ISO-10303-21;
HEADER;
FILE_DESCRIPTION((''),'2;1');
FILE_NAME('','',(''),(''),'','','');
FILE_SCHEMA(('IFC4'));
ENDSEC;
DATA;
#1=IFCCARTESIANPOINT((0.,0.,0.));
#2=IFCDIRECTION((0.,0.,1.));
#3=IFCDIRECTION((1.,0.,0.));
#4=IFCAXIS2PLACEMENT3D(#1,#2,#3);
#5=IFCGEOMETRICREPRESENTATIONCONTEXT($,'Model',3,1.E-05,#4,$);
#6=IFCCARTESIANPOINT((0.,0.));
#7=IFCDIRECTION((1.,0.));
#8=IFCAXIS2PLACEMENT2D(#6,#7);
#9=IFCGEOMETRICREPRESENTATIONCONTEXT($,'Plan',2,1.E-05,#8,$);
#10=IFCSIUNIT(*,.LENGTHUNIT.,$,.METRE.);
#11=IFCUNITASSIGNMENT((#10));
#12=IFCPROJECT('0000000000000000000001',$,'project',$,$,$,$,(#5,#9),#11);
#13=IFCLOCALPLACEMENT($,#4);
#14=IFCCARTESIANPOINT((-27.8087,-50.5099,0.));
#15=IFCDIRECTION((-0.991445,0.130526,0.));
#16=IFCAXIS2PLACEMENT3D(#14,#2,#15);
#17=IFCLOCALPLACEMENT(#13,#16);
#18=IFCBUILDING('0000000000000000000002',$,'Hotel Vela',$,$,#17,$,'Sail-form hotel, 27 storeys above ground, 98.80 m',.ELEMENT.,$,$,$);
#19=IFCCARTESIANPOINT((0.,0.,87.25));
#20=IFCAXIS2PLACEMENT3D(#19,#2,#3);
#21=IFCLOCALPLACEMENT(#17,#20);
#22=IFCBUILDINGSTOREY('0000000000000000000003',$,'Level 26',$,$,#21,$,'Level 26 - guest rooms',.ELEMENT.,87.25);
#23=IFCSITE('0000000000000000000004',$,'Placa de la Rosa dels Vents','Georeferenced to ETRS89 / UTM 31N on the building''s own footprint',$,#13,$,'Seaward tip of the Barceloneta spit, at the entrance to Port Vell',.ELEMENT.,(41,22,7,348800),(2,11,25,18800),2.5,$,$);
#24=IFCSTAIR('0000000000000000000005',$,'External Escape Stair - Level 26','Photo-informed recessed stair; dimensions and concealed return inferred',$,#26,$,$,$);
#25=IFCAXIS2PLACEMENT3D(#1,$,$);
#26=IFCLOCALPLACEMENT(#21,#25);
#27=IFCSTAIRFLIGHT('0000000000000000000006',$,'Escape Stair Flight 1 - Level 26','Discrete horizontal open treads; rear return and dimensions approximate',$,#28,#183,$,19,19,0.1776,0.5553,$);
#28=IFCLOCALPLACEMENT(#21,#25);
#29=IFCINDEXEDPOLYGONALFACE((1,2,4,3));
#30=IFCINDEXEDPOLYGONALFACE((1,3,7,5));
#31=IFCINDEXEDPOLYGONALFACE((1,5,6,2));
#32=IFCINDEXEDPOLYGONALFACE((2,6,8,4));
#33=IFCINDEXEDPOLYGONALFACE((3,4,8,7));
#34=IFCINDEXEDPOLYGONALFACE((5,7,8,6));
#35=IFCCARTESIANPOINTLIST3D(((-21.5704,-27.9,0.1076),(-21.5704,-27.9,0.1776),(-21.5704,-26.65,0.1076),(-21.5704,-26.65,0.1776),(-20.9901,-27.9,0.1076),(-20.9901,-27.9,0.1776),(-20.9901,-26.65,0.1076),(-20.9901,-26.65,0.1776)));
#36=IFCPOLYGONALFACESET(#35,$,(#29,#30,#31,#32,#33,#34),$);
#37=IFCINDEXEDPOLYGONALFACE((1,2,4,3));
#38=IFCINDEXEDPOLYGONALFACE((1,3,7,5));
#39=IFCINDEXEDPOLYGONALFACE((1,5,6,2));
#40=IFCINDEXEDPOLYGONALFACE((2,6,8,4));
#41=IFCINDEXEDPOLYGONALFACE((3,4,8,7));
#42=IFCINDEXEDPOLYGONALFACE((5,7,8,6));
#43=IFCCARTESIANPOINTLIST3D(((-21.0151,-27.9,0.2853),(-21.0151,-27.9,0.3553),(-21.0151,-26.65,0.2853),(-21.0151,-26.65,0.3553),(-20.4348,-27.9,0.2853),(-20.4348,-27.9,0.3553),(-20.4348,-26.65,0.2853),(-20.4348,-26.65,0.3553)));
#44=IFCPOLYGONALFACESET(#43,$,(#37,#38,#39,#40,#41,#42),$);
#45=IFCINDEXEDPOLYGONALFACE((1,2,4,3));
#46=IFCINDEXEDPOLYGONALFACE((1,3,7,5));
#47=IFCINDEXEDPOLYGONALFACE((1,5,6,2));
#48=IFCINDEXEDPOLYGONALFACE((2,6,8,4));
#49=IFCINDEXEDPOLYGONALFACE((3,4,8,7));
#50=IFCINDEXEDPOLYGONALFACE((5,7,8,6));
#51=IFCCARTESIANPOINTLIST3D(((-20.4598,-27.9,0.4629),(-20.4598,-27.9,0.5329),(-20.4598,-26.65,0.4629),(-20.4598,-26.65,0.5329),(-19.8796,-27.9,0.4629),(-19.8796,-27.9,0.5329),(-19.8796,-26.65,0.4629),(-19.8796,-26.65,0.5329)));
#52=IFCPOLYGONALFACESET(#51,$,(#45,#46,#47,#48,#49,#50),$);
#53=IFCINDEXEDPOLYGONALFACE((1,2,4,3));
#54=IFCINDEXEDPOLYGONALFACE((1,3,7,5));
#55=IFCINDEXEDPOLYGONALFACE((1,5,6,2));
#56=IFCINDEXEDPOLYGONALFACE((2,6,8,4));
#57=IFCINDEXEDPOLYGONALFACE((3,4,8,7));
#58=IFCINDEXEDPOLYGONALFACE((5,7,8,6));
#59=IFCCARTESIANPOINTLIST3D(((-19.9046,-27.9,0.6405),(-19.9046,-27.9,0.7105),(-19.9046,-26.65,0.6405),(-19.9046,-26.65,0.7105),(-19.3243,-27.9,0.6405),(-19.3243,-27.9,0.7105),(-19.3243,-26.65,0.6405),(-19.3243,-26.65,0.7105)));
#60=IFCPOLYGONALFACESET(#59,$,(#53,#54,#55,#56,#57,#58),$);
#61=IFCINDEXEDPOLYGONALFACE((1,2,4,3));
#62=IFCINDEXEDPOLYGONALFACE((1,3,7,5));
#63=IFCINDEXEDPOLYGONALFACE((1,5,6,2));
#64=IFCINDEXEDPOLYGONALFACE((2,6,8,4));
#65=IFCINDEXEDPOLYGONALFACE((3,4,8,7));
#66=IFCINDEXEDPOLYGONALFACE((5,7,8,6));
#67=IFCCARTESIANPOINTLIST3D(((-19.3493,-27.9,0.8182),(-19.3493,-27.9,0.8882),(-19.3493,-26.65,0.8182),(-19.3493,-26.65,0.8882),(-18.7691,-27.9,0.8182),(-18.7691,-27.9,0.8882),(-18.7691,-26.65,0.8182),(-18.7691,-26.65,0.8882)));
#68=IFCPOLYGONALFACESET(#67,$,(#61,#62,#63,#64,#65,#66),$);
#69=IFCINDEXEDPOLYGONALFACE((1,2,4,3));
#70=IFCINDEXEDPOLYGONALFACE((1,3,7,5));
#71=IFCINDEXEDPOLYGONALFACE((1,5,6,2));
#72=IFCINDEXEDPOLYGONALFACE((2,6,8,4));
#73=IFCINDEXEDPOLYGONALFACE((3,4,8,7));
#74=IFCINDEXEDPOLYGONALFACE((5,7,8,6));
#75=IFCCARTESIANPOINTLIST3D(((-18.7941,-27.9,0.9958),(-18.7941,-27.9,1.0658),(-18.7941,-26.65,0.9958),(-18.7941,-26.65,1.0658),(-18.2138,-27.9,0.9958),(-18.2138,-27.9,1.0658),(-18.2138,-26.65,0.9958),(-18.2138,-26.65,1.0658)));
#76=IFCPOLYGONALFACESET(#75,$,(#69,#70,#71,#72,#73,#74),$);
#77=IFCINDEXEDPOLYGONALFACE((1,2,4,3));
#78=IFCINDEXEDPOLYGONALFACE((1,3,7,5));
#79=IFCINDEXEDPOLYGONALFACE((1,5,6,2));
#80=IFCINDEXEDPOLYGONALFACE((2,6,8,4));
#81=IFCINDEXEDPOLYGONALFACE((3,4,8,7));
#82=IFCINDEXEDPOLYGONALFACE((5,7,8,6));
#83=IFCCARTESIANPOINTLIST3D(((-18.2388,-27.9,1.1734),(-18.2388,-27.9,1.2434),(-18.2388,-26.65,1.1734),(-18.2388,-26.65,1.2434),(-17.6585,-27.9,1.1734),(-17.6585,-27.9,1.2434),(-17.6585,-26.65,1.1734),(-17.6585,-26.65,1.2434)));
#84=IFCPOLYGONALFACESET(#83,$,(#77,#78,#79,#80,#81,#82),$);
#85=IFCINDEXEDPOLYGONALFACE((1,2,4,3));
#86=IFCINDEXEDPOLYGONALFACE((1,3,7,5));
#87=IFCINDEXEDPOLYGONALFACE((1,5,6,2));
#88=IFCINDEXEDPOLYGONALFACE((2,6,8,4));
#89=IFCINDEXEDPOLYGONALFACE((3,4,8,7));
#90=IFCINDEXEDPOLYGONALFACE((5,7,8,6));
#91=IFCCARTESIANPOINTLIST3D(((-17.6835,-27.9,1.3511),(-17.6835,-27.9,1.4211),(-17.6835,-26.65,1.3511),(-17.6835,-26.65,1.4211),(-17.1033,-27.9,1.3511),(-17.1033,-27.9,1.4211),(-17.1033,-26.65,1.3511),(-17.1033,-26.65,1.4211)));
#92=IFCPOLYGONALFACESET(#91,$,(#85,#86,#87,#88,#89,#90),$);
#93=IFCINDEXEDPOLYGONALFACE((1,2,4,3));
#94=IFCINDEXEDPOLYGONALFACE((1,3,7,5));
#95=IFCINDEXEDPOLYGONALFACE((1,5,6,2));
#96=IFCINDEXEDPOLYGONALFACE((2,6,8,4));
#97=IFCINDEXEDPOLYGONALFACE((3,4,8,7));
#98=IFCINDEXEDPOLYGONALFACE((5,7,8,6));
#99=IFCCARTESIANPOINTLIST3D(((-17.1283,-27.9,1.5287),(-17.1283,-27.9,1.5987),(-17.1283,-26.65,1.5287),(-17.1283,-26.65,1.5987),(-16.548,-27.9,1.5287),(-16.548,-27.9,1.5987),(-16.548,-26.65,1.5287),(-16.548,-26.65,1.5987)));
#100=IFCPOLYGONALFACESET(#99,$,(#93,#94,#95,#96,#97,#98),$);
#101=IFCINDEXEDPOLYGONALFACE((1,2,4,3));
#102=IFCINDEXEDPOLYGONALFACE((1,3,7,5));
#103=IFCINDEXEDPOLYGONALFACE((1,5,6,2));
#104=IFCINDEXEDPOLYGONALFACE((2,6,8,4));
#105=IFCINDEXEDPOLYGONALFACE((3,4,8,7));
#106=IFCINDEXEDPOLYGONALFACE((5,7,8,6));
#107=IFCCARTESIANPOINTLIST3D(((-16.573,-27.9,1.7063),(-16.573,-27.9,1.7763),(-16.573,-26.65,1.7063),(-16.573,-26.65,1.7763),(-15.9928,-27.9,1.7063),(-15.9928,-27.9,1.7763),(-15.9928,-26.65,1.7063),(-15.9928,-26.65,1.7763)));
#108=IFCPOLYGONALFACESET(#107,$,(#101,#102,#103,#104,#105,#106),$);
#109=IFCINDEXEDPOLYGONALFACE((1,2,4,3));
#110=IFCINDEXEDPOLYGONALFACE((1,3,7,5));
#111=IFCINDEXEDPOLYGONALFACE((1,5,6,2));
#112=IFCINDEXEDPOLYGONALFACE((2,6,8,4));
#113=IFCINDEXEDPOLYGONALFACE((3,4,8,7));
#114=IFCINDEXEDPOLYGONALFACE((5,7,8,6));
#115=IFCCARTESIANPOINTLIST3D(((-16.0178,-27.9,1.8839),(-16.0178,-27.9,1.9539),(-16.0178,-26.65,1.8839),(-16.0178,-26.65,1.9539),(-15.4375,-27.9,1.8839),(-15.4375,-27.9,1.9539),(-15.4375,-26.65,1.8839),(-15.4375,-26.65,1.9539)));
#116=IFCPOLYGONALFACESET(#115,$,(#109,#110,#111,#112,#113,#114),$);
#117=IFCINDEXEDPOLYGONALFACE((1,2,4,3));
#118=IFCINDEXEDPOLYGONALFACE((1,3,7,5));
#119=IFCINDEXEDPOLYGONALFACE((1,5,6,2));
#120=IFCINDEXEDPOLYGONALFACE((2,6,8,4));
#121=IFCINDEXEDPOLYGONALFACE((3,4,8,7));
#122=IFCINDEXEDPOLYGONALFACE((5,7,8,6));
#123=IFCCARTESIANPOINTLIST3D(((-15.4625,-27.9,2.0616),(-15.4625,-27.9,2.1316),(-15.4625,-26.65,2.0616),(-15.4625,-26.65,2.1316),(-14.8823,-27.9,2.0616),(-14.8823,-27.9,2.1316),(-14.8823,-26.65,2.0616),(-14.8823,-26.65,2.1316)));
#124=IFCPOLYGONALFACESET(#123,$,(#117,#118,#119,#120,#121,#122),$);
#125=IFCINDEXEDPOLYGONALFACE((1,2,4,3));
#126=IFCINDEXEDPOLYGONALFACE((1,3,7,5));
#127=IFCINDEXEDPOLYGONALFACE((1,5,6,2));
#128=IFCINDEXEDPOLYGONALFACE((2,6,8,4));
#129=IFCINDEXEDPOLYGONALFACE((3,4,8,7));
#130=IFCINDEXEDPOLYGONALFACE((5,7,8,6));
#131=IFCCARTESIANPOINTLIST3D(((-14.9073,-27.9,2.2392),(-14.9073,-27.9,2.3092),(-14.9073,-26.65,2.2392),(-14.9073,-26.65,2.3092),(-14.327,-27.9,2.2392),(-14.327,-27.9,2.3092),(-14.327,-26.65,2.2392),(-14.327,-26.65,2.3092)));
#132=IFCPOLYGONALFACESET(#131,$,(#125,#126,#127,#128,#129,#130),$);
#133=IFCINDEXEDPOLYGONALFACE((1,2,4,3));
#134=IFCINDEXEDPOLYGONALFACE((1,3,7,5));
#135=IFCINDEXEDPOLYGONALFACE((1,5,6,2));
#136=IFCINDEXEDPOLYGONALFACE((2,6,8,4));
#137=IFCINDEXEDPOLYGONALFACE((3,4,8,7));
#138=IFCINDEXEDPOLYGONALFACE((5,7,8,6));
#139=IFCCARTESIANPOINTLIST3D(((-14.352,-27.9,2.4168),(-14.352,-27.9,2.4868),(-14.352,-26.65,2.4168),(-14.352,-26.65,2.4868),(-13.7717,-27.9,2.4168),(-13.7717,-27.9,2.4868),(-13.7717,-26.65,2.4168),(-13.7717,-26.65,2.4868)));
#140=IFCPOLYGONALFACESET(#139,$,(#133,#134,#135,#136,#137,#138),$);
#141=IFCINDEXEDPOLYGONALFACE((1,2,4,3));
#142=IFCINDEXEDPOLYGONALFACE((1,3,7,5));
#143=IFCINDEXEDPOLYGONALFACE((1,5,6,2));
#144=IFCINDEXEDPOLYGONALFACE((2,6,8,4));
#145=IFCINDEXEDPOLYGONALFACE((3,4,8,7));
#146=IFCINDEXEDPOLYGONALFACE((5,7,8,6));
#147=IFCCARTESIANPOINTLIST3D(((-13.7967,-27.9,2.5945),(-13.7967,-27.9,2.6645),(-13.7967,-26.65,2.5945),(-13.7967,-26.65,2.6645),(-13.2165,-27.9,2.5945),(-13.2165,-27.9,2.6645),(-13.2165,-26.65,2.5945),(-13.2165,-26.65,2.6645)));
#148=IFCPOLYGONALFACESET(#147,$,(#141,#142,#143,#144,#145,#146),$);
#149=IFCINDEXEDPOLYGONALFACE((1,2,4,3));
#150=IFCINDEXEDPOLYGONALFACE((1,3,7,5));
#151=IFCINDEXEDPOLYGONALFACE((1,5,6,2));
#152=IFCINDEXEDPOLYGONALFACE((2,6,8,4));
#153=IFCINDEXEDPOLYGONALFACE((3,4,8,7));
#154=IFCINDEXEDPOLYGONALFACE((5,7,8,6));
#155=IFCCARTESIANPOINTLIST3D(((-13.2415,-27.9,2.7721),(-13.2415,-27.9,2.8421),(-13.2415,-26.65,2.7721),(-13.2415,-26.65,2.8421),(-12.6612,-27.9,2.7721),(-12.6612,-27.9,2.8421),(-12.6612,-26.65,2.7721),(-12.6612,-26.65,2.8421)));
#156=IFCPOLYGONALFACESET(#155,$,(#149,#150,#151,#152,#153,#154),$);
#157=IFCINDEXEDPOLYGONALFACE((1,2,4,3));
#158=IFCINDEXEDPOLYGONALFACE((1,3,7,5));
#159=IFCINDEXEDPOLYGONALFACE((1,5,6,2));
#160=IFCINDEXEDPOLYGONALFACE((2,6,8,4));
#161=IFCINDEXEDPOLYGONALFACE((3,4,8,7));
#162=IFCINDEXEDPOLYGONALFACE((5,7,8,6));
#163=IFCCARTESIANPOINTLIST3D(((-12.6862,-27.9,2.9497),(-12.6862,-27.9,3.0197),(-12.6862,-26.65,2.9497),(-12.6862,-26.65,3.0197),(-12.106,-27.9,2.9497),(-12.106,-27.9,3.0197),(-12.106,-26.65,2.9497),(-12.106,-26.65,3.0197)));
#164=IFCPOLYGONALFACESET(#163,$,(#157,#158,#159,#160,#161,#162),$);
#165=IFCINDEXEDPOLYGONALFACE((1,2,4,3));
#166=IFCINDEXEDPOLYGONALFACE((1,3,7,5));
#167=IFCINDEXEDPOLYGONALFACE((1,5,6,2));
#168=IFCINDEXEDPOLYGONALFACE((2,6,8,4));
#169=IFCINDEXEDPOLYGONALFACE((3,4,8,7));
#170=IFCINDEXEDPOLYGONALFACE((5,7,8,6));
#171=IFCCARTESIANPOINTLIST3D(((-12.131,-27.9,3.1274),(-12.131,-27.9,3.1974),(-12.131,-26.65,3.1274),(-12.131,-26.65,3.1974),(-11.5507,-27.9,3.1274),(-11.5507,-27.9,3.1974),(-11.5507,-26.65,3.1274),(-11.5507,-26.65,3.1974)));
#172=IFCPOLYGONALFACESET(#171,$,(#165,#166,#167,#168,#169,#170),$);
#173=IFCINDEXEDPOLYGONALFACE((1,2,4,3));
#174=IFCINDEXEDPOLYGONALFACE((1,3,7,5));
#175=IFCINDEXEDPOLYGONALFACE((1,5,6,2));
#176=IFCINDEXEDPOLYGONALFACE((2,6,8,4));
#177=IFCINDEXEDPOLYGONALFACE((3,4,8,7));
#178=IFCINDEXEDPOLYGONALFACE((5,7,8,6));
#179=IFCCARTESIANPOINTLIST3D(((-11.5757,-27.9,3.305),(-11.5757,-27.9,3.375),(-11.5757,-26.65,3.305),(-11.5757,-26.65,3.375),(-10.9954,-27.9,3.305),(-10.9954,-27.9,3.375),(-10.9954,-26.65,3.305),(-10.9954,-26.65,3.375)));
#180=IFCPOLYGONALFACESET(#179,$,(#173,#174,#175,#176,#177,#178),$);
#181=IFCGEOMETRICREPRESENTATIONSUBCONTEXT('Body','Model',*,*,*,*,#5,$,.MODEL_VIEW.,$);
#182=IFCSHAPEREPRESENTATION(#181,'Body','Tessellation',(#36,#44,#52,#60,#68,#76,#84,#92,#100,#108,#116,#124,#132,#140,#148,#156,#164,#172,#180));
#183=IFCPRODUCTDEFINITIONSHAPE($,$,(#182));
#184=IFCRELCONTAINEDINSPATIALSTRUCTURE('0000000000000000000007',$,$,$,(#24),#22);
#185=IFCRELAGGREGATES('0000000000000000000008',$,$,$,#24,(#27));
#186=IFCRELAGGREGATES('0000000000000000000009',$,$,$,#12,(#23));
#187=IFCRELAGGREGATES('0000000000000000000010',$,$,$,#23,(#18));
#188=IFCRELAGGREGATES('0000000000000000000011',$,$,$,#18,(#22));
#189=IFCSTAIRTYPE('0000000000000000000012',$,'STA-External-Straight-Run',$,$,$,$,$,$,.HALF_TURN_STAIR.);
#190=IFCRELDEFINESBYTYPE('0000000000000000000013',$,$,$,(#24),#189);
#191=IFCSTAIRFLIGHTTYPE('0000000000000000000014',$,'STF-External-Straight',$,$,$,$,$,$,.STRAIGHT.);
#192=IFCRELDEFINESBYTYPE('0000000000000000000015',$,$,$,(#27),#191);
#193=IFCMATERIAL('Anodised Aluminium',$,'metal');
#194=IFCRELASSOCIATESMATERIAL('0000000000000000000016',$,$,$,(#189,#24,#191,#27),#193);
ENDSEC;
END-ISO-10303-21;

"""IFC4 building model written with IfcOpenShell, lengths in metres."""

from ifc_helpers import new_model, si_unit, frame, origin_with_axes, origin_2d_with_axis, place, context, subcontext, project, spatial, line, indexed_curve, outline, extrude, material, type_object, element, aggregate, save


model = new_model("IFC4")

# Units and contexts
model_context = context("Model", 3, precision=1e-05, world=origin_with_axes())
plan_context = context("Plan", 2, precision=1e-05, world=origin_2d_with_axis())
body_context = subcontext(model_context, "Body", "Model", "MODEL_VIEW")
ifc_project = project(units=[si_unit("LENGTHUNIT", "METRE")], contexts=[model_context, plan_context])

# Site, building, storey
site_placement = place(None, origin_with_axes())
site = spatial("IfcSite", under=ifc_project, at=site_placement, Name="Placa de la Rosa dels Vents", Description="Georeferenced to ETRS89 / UTM 31N on the building's own footprint", LongName="Seaward tip of the Barceloneta spit, at the entrance to Port Vell", CompositionType="ELEMENT", RefLatitude=(41, 22, 7, 348800), RefLongitude=(2, 11, 25, 18800), RefElevation=2.5)
building_placement = place(site_placement, frame((-27.8087, -50.5099, 0.0), z_axis=(0.0, 0.0, 1.0), x_axis=(-0.991445, 0.130526, 0.0)))
building = spatial("IfcBuilding", under=site, at=building_placement, Name="Hotel Vela", LongName="Sail-form hotel, 27 storeys above ground, 98.80 m", CompositionType="ELEMENT")
storey_placement = place(building_placement, frame((0.0, 0.0, 87.25), z_axis=(0.0, 0.0, 1.0), x_axis=(1.0, 0.0, 0.0)))
storey = spatial("IfcBuildingStorey", under=building, at=storey_placement, Name="Level 26", LongName="Level 26 - guest rooms", CompositionType="ELEMENT", Elevation=87.25)

# Stair
ifc_material_1 = material(Name="Anodised Aluminium", Category="metal")
stair_type = type_object("IfcStairType", Name="STA-External-Straight-Run", PredefinedType="HALF_TURN_STAIR", material=ifc_material_1)
stair_placement = place(storey_placement, frame((0.0, 0.0, -87.25), z_axis=(0.0, 0.0, 1.0), x_axis=(1.0, 0.0, 0.0)))
stair = element("IfcStair", 1, at=stair_placement, inside=storey, type_object=stair_type, material=ifc_material_1, Name="External Escape Stair - Level 26", Description="Photo-informed recessed stair; dimensions and concealed return inferred")

# Stair flight
stair_flight_type = type_object("IfcStairFlightType", Name="STF-External-Straight", PredefinedType="STRAIGHT", material=ifc_material_1)
stair_flight_1_placement = place(stair_placement, origin_with_axes())
stair_flight_1 = element("IfcStairFlight", 2, at=stair_flight_1_placement, type_object=stair_flight_type, material=ifc_material_1, Name="Escape Stair Flight 1 - Level 26", Description="Discrete horizontal open treads; rear return and dimensions approximate", NumberOfRisers=19, NumberOfTreads=19, RiserHeight=0.1776, TreadLength=0.5553, context=body_context, shape_type="SweptSolid", body=[
    extrude(outline(indexed_curve([(0.0, 0.0), (0.5803, 0.0), (0.5803, 1.25), (0.0, 1.25)], segments=[line(1, 2, 3, 4, 1)])), frame((-21.5704, -27.9, 87.3576), z_axis=(0.0, 0.0, 1.0), x_axis=(1.0, 0.0, 0.0)), (0.0, 0.0, 1.0), 0.07),
    extrude(outline(indexed_curve([(0.0, 0.0), (0.5803, 0.0), (0.5803, 1.25), (0.0, 1.25)], segments=[line(1, 2, 3, 4, 1)])), frame((-21.0151, -27.9, 87.5353), z_axis=(0.0, 0.0, 1.0), x_axis=(1.0, 0.0, 0.0)), (0.0, 0.0, 1.0), 0.07),
    extrude(outline(indexed_curve([(0.0, 0.0), (0.5803, 0.0), (0.5803, 1.25), (0.0, 1.25)], segments=[line(1, 2, 3, 4, 1)])), frame((-20.4598, -27.9, 87.7129), z_axis=(0.0, 0.0, 1.0), x_axis=(1.0, 0.0, 0.0)), (0.0, 0.0, 1.0), 0.07),
    extrude(outline(indexed_curve([(0.0, 0.0), (0.5803, 0.0), (0.5803, 1.25), (0.0, 1.25)], segments=[line(1, 2, 3, 4, 1)])), frame((-19.9046, -27.9, 87.8905), z_axis=(0.0, 0.0, 1.0), x_axis=(1.0, 0.0, 0.0)), (0.0, 0.0, 1.0), 0.07),
    extrude(outline(indexed_curve([(0.0, 0.0), (0.5803, 0.0), (0.5803, 1.25), (0.0, 1.25)], segments=[line(1, 2, 3, 4, 1)])), frame((-19.3493, -27.9, 88.0682), z_axis=(0.0, 0.0, 1.0), x_axis=(1.0, 0.0, 0.0)), (0.0, 0.0, 1.0), 0.07),
    extrude(outline(indexed_curve([(0.0, 0.0), (0.5803, 0.0), (0.5803, 1.25), (0.0, 1.25)], segments=[line(1, 2, 3, 4, 1)])), frame((-18.7941, -27.9, 88.2458), z_axis=(0.0, 0.0, 1.0), x_axis=(1.0, 0.0, 0.0)), (0.0, 0.0, 1.0), 0.07),
    extrude(outline(indexed_curve([(0.0, 0.0), (0.5803, 0.0), (0.5803, 1.25), (0.0, 1.25)], segments=[line(1, 2, 3, 4, 1)])), frame((-18.2388, -27.9, 88.4234), z_axis=(0.0, 0.0, 1.0), x_axis=(1.0, 0.0, 0.0)), (0.0, 0.0, 1.0), 0.07),
    extrude(outline(indexed_curve([(0.0, 0.0), (0.5803, 0.0), (0.5803, 1.25), (0.0, 1.25)], segments=[line(1, 2, 3, 4, 1)])), frame((-17.6835, -27.9, 88.6011), z_axis=(0.0, 0.0, 1.0), x_axis=(1.0, 0.0, 0.0)), (0.0, 0.0, 1.0), 0.07),
    extrude(outline(indexed_curve([(0.0, 0.0), (0.5803, 0.0), (0.5803, 1.25), (0.0, 1.25)], segments=[line(1, 2, 3, 4, 1)])), frame((-17.1283, -27.9, 88.7787), z_axis=(0.0, 0.0, 1.0), x_axis=(1.0, 0.0, 0.0)), (0.0, 0.0, 1.0), 0.07),
    extrude(outline(indexed_curve([(0.0, 0.0), (0.5803, 0.0), (0.5803, 1.25), (0.0, 1.25)], segments=[line(1, 2, 3, 4, 1)])), frame((-16.573, -27.9, 88.9563), z_axis=(0.0, 0.0, 1.0), x_axis=(1.0, 0.0, 0.0)), (0.0, 0.0, 1.0), 0.07),
    extrude(outline(indexed_curve([(0.0, 0.0), (0.5803, 0.0), (0.5803, 1.25), (0.0, 1.25)], segments=[line(1, 2, 3, 4, 1)])), frame((-16.0178, -27.9, 89.1339), z_axis=(0.0, 0.0, 1.0), x_axis=(1.0, 0.0, 0.0)), (0.0, 0.0, 1.0), 0.07),
    extrude(outline(indexed_curve([(0.0, 0.0), (0.5803, 0.0), (0.5803, 1.25), (0.0, 1.25)], segments=[line(1, 2, 3, 4, 1)])), frame((-15.4625, -27.9, 89.3116), z_axis=(0.0, 0.0, 1.0), x_axis=(1.0, 0.0, 0.0)), (0.0, 0.0, 1.0), 0.07),
    extrude(outline(indexed_curve([(0.0, 0.0), (0.5803, 0.0), (0.5803, 1.25), (0.0, 1.25)], segments=[line(1, 2, 3, 4, 1)])), frame((-14.9073, -27.9, 89.4892), z_axis=(0.0, 0.0, 1.0), x_axis=(1.0, 0.0, 0.0)), (0.0, 0.0, 1.0), 0.07),
    extrude(outline(indexed_curve([(0.0, 0.0), (0.5803, 0.0), (0.5803, 1.25), (0.0, 1.25)], segments=[line(1, 2, 3, 4, 1)])), frame((-14.352, -27.9, 89.6668), z_axis=(0.0, 0.0, 1.0), x_axis=(1.0, 0.0, 0.0)), (0.0, 0.0, 1.0), 0.07),
    extrude(outline(indexed_curve([(0.0, 0.0), (0.5803, 0.0), (0.5803, 1.25), (0.0, 1.25)], segments=[line(1, 2, 3, 4, 1)])), frame((-13.7967, -27.9, 89.8445), z_axis=(0.0, 0.0, 1.0), x_axis=(1.0, 0.0, 0.0)), (0.0, 0.0, 1.0), 0.07),
    extrude(outline(indexed_curve([(0.0, 0.0), (0.5803, 0.0), (0.5803, 1.25), (0.0, 1.25)], segments=[line(1, 2, 3, 4, 1)])), frame((-13.2415, -27.9, 90.0221), z_axis=(0.0, 0.0, 1.0), x_axis=(1.0, 0.0, 0.0)), (0.0, 0.0, 1.0), 0.07),
    extrude(outline(indexed_curve([(0.0, 0.0), (0.5803, 0.0), (0.5803, 1.25), (0.0, 1.25)], segments=[line(1, 2, 3, 4, 1)])), frame((-12.6862, -27.9, 90.1997), z_axis=(0.0, 0.0, 1.0), x_axis=(1.0, 0.0, 0.0)), (0.0, 0.0, 1.0), 0.07),
    extrude(outline(indexed_curve([(0.0, 0.0), (0.5803, 0.0), (0.5803, 1.25), (0.0, 1.25)], segments=[line(1, 2, 3, 4, 1)])), frame((-12.131, -27.9, 90.3774), z_axis=(0.0, 0.0, 1.0), x_axis=(1.0, 0.0, 0.0)), (0.0, 0.0, 1.0), 0.07),
    extrude(outline(indexed_curve([(0.0, 0.0), (0.5803, 0.0), (0.5803, 1.25), (0.0, 1.25)], segments=[line(1, 2, 3, 4, 1)])), frame((-11.5757, -27.9, 90.555), z_axis=(0.0, 0.0, 1.0), x_axis=(1.0, 0.0, 0.0)), (0.0, 0.0, 1.0), 0.07),
])

aggregate(stair, [stair_flight_1])

save(model, "model.ifc")
